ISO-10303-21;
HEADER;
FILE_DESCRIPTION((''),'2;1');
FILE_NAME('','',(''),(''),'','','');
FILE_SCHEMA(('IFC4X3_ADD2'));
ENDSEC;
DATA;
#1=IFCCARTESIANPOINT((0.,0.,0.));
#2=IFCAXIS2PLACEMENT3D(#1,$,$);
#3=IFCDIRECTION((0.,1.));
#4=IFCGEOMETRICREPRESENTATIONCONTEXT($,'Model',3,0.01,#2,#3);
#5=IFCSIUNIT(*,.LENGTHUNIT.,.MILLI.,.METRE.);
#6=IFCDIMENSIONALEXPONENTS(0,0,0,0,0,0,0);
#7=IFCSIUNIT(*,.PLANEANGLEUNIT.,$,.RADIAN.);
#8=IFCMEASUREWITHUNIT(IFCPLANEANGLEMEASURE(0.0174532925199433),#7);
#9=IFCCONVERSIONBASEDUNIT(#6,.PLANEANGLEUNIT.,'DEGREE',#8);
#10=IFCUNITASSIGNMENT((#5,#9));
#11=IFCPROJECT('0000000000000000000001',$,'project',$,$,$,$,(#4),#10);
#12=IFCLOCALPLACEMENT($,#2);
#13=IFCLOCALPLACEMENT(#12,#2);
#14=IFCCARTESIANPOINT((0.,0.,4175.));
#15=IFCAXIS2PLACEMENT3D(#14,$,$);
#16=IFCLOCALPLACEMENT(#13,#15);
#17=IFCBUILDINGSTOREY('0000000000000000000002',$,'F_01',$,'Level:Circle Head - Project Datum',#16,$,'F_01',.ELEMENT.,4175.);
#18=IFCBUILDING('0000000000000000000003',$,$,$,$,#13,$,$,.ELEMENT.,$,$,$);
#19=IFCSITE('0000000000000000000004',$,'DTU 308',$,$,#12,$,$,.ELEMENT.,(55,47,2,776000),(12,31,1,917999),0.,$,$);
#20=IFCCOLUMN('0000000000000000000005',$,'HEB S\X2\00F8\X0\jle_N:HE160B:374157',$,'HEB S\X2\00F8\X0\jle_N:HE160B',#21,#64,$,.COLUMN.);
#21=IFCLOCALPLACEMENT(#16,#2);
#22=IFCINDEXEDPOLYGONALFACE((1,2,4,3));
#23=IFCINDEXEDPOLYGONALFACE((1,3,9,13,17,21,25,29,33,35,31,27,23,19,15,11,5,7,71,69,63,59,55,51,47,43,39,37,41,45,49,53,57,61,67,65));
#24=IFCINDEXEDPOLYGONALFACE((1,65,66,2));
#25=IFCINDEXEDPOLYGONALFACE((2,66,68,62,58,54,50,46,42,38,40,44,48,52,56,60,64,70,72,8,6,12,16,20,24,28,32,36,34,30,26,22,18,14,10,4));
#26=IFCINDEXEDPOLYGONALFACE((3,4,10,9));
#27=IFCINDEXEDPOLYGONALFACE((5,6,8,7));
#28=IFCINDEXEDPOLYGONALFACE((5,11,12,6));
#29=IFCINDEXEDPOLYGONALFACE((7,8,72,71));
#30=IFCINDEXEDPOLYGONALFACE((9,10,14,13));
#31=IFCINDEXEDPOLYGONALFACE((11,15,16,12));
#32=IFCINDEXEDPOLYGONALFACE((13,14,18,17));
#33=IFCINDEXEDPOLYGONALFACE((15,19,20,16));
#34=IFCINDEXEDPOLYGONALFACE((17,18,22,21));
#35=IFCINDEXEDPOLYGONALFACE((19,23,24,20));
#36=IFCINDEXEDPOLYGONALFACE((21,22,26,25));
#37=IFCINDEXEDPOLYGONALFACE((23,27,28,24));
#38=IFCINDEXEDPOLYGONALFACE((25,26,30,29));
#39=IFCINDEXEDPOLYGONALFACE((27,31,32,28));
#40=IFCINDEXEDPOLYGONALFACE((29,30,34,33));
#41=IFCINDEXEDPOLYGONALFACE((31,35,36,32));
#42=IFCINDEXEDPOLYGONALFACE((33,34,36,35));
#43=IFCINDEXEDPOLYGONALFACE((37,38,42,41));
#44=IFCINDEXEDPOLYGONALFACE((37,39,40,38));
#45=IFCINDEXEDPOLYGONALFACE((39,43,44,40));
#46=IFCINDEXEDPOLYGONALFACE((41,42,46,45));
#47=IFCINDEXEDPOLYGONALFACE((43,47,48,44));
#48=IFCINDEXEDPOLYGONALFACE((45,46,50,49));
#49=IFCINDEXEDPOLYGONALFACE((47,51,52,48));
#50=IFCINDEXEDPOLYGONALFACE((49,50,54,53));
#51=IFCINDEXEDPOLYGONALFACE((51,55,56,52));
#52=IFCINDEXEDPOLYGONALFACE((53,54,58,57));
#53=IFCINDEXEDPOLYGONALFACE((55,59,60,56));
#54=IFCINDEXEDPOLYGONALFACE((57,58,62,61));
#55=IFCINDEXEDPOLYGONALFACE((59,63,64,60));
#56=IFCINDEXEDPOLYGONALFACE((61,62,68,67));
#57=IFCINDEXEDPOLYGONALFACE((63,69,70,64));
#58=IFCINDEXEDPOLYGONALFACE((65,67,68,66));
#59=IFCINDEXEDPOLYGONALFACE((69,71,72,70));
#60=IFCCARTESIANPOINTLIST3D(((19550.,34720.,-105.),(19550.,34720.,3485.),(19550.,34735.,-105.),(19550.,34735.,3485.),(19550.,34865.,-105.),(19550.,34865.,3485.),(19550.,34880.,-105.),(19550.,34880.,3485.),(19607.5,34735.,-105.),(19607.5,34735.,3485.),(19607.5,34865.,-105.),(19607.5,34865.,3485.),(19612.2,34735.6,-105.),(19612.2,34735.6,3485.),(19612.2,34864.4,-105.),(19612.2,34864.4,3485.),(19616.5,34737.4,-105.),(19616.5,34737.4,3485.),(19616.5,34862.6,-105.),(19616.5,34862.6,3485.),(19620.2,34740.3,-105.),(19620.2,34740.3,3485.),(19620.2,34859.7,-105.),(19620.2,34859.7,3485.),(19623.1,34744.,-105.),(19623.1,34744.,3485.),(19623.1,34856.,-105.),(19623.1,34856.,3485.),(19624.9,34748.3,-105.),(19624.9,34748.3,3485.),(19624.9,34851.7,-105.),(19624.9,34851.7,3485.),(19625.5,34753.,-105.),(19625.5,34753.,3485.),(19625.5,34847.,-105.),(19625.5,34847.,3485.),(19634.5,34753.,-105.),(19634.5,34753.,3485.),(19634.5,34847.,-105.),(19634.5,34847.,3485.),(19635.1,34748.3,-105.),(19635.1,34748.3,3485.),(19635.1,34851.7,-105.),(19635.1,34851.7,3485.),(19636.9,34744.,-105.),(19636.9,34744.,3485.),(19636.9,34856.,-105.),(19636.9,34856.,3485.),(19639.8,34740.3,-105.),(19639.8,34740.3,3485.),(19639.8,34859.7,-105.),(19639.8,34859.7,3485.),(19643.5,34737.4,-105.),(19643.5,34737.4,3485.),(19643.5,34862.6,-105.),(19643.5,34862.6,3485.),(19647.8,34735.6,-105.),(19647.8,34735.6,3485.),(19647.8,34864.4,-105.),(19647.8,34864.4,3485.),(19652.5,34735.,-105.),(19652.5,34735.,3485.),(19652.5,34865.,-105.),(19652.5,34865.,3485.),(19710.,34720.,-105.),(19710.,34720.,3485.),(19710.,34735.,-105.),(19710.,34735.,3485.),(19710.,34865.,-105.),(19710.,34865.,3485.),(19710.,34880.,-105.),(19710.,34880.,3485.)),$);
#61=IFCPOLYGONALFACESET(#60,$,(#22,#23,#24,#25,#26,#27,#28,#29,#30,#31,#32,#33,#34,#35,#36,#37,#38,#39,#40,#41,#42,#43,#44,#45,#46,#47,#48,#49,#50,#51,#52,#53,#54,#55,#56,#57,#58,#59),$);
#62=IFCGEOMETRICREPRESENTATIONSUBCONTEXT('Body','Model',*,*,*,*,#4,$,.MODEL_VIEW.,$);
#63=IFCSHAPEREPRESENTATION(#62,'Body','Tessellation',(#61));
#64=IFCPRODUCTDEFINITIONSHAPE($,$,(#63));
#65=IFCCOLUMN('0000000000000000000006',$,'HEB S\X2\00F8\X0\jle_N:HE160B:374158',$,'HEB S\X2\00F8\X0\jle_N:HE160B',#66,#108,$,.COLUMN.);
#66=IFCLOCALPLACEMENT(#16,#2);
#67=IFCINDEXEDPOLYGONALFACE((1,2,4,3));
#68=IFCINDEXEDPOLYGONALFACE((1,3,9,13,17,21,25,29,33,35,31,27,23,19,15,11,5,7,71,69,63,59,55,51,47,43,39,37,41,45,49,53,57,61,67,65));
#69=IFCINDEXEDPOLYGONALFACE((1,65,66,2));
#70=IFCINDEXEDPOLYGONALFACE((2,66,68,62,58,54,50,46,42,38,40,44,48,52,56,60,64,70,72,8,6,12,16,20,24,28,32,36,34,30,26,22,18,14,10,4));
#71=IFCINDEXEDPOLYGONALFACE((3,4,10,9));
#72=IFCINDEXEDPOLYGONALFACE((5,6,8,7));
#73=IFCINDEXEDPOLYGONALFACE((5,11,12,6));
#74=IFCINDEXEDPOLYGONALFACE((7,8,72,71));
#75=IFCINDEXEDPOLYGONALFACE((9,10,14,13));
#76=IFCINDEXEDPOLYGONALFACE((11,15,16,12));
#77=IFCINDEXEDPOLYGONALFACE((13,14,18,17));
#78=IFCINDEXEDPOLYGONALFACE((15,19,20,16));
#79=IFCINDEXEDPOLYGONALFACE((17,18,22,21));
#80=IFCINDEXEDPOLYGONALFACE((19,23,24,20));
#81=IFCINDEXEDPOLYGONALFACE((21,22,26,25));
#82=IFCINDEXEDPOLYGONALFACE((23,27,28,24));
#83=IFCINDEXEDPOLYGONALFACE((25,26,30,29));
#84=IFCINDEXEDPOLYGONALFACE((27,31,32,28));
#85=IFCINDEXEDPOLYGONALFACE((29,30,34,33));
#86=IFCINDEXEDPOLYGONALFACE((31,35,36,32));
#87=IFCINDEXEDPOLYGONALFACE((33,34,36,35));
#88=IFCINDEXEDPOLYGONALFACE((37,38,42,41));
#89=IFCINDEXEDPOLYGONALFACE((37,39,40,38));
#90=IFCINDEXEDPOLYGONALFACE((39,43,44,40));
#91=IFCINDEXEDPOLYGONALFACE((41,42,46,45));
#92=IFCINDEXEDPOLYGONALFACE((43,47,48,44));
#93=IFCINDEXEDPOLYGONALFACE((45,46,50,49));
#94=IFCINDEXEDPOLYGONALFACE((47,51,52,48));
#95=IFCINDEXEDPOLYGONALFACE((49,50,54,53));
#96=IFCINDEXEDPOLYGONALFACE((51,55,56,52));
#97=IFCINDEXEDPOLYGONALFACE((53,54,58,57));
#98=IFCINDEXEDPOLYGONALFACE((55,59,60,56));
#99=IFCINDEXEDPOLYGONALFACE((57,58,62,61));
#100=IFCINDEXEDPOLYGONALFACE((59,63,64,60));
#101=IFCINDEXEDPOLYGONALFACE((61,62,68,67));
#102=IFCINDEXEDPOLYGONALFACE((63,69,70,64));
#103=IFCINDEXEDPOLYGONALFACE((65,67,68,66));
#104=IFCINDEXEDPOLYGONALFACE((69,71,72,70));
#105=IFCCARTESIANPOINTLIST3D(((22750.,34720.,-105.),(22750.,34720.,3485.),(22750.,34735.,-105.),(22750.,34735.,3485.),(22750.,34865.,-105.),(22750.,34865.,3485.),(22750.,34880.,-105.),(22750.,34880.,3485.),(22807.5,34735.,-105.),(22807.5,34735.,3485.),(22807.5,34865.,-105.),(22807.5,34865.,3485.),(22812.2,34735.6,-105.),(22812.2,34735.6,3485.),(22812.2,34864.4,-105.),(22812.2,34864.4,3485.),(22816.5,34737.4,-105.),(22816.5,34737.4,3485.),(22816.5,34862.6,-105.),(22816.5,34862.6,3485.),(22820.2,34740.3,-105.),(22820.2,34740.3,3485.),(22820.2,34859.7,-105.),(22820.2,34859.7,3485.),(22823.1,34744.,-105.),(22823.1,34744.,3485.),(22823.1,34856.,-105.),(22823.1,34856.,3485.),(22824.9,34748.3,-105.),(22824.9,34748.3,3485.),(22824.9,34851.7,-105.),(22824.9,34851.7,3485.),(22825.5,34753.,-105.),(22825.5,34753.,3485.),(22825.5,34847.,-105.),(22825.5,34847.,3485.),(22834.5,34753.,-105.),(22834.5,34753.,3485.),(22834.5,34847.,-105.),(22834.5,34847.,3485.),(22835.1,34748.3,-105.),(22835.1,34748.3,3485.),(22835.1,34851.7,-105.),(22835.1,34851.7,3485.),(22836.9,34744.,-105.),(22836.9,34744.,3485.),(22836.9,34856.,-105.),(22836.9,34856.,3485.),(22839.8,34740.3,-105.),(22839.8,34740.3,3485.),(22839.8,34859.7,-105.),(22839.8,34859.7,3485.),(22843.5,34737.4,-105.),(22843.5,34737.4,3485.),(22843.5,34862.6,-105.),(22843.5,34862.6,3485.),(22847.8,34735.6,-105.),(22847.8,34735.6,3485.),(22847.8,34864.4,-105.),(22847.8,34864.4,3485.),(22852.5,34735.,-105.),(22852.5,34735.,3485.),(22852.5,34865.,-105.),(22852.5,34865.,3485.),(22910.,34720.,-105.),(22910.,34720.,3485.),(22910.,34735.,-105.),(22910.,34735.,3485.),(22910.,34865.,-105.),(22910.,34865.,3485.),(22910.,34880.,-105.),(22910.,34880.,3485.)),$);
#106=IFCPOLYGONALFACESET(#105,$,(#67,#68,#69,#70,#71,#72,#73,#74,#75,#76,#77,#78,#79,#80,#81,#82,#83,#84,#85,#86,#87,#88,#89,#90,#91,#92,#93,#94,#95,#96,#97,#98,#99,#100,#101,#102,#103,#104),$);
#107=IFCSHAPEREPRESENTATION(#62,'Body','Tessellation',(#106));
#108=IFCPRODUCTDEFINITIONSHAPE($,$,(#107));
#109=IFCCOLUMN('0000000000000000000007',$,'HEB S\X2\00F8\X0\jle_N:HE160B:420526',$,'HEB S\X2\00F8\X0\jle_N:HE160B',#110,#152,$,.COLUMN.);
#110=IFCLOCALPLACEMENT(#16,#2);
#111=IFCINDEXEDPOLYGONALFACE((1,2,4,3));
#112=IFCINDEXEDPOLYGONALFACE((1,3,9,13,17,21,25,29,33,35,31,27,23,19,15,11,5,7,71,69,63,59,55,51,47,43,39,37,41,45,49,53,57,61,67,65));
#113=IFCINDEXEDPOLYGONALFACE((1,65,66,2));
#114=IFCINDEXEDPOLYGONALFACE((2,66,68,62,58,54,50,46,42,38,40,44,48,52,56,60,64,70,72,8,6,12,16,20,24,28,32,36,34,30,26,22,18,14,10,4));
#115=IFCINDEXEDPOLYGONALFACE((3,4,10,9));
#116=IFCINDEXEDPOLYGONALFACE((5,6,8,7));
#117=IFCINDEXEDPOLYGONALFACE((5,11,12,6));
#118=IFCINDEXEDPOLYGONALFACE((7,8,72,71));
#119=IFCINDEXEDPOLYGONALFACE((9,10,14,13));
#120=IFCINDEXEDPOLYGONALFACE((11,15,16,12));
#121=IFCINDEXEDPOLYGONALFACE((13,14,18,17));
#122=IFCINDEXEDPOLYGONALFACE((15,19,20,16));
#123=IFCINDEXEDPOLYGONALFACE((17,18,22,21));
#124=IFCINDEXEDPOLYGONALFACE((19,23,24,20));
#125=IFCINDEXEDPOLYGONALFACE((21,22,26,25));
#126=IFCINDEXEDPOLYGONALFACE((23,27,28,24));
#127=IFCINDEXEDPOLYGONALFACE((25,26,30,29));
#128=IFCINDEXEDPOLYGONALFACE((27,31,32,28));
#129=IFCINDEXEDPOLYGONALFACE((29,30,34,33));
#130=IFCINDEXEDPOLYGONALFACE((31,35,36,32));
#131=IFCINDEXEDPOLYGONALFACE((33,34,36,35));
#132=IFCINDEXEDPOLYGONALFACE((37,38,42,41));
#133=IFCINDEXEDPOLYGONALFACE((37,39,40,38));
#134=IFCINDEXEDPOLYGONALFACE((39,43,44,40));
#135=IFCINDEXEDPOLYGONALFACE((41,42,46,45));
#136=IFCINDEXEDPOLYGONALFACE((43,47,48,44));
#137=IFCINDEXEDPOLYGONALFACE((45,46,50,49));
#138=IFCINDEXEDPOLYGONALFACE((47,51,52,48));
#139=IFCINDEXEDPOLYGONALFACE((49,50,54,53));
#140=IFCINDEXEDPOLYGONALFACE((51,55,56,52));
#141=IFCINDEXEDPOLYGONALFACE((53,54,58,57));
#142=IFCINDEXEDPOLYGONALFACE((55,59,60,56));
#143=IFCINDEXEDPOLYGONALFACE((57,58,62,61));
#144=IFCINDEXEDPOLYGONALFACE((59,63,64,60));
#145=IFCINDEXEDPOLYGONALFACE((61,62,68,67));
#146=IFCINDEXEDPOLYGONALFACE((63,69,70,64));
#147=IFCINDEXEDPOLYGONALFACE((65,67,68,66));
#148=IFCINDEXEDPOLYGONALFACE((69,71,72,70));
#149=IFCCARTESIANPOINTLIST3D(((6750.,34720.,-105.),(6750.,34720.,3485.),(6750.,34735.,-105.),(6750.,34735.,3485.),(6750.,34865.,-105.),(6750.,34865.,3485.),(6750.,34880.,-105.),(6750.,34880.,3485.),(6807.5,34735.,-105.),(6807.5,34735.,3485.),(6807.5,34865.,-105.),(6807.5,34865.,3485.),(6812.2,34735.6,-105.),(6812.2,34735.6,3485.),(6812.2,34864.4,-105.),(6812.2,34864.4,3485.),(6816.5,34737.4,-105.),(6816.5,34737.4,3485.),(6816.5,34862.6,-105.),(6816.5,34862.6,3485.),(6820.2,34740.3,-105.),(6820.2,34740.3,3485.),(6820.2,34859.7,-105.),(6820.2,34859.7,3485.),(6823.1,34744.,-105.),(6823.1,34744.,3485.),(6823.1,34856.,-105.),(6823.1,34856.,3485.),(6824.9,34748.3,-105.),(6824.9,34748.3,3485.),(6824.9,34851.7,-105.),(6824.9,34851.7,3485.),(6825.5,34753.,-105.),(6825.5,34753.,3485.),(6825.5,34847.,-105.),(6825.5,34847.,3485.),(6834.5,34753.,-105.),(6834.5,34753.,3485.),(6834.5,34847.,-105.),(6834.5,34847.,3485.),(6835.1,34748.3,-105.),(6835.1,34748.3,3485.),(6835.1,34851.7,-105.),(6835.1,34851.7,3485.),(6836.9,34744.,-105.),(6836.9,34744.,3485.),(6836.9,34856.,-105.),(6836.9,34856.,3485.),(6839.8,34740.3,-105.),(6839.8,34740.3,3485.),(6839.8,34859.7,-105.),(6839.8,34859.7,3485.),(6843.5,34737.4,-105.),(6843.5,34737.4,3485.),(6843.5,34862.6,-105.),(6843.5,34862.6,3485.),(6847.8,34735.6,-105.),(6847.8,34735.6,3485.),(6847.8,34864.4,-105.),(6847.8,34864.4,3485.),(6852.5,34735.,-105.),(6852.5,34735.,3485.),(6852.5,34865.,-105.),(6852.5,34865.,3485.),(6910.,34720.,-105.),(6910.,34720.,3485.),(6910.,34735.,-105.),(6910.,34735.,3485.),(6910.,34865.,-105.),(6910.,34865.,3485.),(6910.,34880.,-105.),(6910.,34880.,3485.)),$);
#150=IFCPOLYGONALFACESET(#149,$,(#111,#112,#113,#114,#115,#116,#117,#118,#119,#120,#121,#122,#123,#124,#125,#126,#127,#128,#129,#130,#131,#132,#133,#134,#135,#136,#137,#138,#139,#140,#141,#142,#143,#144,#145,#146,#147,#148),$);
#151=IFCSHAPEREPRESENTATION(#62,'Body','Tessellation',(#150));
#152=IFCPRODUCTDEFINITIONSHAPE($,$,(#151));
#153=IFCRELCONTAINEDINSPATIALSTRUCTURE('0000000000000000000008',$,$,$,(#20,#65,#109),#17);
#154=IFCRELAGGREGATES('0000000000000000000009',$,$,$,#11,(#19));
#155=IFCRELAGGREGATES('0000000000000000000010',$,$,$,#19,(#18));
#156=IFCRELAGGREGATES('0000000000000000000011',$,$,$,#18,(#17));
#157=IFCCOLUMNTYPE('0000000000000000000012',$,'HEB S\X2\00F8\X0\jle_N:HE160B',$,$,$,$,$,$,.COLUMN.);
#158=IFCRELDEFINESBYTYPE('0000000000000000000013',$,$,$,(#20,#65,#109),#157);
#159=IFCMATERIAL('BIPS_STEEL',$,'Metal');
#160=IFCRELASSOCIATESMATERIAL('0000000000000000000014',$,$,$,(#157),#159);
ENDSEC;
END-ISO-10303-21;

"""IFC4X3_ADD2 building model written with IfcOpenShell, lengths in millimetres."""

from ifc_helpers import new_model, entity, si_unit, converted_unit, direction, frame, frame_2d, origin, place, context, subcontext, project, spatial, i_section, extrude, source, transform, mapped, material, material_profile, profile_set, type_object, element, save


model = new_model("IFC4X3_ADD2")

# Units and contexts
model_context = context("Model", 3, precision=0.01, world=origin(), true_north=direction((0.0, 1.0)))
body_context = subcontext(model_context, "Body", "Model", "MODEL_VIEW")
ifc_project = project(units=[si_unit("LENGTHUNIT", "METRE", prefix="MILLI"), converted_unit("PLANEANGLEUNIT", "DEGREE", entity("IfcPlaneAngleMeasure", 0.0174532925199433), si_unit("PLANEANGLEUNIT", "RADIAN"), dimensions=[0, 0, 0, 0, 0, 0, 0])], contexts=[model_context])

# Site, building, storey
site_placement = place(None, origin())
site = spatial("IfcSite", under=ifc_project, at=site_placement, Name="DTU 308", CompositionType="ELEMENT", RefLatitude=(55, 47, 2, 776000), RefLongitude=(12, 31, 1, 917999), RefElevation=0.0)
building_placement = place(site_placement, origin())
building = spatial("IfcBuilding", under=site, at=building_placement, CompositionType="ELEMENT")
storey_placement = place(building_placement, frame((0.0, 0.0, 4175.0)))
storey = spatial("IfcBuildingStorey", under=building, at=storey_placement, Name="F_01", ObjectType="Level:Circle Head - Project Datum", LongName="F_01", CompositionType="ELEMENT", Elevation=4175.0)

# Columns
ifc_material_1 = material(Name="BIPS_STEEL", Category="Metal")
ifc_material_profile_1 = material_profile(ifc_material_1, i_section(OverallWidth=160.0, OverallDepth=160.0, WebThickness=9.0, FlangeThickness=15.0, FilletRadius=18.0, at=frame_2d((0.0, 0.0), x_axis=(1.0, 0.0))), Name="HE160B")
ifc_profile_set_1 = profile_set([ifc_material_profile_1], Name="HE160B")
column_type_1 = type_object("IfcColumnType", Name="HEB Søjle_N:HE160B", PredefinedType="COLUMN", material=ifc_profile_set_1)
shared_shape_1 = source(origin(), body_context, "Body", "SweptSolid", [
    extrude(i_section(OverallWidth=160.0, OverallDepth=160.0, WebThickness=9.0, FlangeThickness=15.0, FilletRadius=18.0, at=frame_2d((0.0, 0.0), x_axis=(1.0, 0.0))), frame((0.0, 0.0, 4070.0), z_axis=(0.0, 0.0, 1.0), x_axis=(-1.0, 0.0, 0.0)), (0.0, 0.0, 1.0), 3590.0),
])
for number, where, name in (
    (1, (19630.0, 34800.0, -4175.0), "HEB Søjle_N:HE160B:374157"),
    (2, (22830.0, 34800.0, -4175.0), "HEB Søjle_N:HE160B:374158"),
    (3, (6830.0, 34800.0, -4175.0), "HEB Søjle_N:HE160B:420526"),
):
    element("IfcColumn", number, at=place(storey_placement, frame(where)), inside=storey, type_object=column_type_1, Name=name, ObjectType="HEB Søjle_N:HE160B", PredefinedType="COLUMN", context=body_context, shape_type="MappedRepresentation", body=[
        mapped(shared_shape_1, transform((0.0, 0.0, 0.0), scale=1.0)),
    ])

save(model, "model.ifc")
